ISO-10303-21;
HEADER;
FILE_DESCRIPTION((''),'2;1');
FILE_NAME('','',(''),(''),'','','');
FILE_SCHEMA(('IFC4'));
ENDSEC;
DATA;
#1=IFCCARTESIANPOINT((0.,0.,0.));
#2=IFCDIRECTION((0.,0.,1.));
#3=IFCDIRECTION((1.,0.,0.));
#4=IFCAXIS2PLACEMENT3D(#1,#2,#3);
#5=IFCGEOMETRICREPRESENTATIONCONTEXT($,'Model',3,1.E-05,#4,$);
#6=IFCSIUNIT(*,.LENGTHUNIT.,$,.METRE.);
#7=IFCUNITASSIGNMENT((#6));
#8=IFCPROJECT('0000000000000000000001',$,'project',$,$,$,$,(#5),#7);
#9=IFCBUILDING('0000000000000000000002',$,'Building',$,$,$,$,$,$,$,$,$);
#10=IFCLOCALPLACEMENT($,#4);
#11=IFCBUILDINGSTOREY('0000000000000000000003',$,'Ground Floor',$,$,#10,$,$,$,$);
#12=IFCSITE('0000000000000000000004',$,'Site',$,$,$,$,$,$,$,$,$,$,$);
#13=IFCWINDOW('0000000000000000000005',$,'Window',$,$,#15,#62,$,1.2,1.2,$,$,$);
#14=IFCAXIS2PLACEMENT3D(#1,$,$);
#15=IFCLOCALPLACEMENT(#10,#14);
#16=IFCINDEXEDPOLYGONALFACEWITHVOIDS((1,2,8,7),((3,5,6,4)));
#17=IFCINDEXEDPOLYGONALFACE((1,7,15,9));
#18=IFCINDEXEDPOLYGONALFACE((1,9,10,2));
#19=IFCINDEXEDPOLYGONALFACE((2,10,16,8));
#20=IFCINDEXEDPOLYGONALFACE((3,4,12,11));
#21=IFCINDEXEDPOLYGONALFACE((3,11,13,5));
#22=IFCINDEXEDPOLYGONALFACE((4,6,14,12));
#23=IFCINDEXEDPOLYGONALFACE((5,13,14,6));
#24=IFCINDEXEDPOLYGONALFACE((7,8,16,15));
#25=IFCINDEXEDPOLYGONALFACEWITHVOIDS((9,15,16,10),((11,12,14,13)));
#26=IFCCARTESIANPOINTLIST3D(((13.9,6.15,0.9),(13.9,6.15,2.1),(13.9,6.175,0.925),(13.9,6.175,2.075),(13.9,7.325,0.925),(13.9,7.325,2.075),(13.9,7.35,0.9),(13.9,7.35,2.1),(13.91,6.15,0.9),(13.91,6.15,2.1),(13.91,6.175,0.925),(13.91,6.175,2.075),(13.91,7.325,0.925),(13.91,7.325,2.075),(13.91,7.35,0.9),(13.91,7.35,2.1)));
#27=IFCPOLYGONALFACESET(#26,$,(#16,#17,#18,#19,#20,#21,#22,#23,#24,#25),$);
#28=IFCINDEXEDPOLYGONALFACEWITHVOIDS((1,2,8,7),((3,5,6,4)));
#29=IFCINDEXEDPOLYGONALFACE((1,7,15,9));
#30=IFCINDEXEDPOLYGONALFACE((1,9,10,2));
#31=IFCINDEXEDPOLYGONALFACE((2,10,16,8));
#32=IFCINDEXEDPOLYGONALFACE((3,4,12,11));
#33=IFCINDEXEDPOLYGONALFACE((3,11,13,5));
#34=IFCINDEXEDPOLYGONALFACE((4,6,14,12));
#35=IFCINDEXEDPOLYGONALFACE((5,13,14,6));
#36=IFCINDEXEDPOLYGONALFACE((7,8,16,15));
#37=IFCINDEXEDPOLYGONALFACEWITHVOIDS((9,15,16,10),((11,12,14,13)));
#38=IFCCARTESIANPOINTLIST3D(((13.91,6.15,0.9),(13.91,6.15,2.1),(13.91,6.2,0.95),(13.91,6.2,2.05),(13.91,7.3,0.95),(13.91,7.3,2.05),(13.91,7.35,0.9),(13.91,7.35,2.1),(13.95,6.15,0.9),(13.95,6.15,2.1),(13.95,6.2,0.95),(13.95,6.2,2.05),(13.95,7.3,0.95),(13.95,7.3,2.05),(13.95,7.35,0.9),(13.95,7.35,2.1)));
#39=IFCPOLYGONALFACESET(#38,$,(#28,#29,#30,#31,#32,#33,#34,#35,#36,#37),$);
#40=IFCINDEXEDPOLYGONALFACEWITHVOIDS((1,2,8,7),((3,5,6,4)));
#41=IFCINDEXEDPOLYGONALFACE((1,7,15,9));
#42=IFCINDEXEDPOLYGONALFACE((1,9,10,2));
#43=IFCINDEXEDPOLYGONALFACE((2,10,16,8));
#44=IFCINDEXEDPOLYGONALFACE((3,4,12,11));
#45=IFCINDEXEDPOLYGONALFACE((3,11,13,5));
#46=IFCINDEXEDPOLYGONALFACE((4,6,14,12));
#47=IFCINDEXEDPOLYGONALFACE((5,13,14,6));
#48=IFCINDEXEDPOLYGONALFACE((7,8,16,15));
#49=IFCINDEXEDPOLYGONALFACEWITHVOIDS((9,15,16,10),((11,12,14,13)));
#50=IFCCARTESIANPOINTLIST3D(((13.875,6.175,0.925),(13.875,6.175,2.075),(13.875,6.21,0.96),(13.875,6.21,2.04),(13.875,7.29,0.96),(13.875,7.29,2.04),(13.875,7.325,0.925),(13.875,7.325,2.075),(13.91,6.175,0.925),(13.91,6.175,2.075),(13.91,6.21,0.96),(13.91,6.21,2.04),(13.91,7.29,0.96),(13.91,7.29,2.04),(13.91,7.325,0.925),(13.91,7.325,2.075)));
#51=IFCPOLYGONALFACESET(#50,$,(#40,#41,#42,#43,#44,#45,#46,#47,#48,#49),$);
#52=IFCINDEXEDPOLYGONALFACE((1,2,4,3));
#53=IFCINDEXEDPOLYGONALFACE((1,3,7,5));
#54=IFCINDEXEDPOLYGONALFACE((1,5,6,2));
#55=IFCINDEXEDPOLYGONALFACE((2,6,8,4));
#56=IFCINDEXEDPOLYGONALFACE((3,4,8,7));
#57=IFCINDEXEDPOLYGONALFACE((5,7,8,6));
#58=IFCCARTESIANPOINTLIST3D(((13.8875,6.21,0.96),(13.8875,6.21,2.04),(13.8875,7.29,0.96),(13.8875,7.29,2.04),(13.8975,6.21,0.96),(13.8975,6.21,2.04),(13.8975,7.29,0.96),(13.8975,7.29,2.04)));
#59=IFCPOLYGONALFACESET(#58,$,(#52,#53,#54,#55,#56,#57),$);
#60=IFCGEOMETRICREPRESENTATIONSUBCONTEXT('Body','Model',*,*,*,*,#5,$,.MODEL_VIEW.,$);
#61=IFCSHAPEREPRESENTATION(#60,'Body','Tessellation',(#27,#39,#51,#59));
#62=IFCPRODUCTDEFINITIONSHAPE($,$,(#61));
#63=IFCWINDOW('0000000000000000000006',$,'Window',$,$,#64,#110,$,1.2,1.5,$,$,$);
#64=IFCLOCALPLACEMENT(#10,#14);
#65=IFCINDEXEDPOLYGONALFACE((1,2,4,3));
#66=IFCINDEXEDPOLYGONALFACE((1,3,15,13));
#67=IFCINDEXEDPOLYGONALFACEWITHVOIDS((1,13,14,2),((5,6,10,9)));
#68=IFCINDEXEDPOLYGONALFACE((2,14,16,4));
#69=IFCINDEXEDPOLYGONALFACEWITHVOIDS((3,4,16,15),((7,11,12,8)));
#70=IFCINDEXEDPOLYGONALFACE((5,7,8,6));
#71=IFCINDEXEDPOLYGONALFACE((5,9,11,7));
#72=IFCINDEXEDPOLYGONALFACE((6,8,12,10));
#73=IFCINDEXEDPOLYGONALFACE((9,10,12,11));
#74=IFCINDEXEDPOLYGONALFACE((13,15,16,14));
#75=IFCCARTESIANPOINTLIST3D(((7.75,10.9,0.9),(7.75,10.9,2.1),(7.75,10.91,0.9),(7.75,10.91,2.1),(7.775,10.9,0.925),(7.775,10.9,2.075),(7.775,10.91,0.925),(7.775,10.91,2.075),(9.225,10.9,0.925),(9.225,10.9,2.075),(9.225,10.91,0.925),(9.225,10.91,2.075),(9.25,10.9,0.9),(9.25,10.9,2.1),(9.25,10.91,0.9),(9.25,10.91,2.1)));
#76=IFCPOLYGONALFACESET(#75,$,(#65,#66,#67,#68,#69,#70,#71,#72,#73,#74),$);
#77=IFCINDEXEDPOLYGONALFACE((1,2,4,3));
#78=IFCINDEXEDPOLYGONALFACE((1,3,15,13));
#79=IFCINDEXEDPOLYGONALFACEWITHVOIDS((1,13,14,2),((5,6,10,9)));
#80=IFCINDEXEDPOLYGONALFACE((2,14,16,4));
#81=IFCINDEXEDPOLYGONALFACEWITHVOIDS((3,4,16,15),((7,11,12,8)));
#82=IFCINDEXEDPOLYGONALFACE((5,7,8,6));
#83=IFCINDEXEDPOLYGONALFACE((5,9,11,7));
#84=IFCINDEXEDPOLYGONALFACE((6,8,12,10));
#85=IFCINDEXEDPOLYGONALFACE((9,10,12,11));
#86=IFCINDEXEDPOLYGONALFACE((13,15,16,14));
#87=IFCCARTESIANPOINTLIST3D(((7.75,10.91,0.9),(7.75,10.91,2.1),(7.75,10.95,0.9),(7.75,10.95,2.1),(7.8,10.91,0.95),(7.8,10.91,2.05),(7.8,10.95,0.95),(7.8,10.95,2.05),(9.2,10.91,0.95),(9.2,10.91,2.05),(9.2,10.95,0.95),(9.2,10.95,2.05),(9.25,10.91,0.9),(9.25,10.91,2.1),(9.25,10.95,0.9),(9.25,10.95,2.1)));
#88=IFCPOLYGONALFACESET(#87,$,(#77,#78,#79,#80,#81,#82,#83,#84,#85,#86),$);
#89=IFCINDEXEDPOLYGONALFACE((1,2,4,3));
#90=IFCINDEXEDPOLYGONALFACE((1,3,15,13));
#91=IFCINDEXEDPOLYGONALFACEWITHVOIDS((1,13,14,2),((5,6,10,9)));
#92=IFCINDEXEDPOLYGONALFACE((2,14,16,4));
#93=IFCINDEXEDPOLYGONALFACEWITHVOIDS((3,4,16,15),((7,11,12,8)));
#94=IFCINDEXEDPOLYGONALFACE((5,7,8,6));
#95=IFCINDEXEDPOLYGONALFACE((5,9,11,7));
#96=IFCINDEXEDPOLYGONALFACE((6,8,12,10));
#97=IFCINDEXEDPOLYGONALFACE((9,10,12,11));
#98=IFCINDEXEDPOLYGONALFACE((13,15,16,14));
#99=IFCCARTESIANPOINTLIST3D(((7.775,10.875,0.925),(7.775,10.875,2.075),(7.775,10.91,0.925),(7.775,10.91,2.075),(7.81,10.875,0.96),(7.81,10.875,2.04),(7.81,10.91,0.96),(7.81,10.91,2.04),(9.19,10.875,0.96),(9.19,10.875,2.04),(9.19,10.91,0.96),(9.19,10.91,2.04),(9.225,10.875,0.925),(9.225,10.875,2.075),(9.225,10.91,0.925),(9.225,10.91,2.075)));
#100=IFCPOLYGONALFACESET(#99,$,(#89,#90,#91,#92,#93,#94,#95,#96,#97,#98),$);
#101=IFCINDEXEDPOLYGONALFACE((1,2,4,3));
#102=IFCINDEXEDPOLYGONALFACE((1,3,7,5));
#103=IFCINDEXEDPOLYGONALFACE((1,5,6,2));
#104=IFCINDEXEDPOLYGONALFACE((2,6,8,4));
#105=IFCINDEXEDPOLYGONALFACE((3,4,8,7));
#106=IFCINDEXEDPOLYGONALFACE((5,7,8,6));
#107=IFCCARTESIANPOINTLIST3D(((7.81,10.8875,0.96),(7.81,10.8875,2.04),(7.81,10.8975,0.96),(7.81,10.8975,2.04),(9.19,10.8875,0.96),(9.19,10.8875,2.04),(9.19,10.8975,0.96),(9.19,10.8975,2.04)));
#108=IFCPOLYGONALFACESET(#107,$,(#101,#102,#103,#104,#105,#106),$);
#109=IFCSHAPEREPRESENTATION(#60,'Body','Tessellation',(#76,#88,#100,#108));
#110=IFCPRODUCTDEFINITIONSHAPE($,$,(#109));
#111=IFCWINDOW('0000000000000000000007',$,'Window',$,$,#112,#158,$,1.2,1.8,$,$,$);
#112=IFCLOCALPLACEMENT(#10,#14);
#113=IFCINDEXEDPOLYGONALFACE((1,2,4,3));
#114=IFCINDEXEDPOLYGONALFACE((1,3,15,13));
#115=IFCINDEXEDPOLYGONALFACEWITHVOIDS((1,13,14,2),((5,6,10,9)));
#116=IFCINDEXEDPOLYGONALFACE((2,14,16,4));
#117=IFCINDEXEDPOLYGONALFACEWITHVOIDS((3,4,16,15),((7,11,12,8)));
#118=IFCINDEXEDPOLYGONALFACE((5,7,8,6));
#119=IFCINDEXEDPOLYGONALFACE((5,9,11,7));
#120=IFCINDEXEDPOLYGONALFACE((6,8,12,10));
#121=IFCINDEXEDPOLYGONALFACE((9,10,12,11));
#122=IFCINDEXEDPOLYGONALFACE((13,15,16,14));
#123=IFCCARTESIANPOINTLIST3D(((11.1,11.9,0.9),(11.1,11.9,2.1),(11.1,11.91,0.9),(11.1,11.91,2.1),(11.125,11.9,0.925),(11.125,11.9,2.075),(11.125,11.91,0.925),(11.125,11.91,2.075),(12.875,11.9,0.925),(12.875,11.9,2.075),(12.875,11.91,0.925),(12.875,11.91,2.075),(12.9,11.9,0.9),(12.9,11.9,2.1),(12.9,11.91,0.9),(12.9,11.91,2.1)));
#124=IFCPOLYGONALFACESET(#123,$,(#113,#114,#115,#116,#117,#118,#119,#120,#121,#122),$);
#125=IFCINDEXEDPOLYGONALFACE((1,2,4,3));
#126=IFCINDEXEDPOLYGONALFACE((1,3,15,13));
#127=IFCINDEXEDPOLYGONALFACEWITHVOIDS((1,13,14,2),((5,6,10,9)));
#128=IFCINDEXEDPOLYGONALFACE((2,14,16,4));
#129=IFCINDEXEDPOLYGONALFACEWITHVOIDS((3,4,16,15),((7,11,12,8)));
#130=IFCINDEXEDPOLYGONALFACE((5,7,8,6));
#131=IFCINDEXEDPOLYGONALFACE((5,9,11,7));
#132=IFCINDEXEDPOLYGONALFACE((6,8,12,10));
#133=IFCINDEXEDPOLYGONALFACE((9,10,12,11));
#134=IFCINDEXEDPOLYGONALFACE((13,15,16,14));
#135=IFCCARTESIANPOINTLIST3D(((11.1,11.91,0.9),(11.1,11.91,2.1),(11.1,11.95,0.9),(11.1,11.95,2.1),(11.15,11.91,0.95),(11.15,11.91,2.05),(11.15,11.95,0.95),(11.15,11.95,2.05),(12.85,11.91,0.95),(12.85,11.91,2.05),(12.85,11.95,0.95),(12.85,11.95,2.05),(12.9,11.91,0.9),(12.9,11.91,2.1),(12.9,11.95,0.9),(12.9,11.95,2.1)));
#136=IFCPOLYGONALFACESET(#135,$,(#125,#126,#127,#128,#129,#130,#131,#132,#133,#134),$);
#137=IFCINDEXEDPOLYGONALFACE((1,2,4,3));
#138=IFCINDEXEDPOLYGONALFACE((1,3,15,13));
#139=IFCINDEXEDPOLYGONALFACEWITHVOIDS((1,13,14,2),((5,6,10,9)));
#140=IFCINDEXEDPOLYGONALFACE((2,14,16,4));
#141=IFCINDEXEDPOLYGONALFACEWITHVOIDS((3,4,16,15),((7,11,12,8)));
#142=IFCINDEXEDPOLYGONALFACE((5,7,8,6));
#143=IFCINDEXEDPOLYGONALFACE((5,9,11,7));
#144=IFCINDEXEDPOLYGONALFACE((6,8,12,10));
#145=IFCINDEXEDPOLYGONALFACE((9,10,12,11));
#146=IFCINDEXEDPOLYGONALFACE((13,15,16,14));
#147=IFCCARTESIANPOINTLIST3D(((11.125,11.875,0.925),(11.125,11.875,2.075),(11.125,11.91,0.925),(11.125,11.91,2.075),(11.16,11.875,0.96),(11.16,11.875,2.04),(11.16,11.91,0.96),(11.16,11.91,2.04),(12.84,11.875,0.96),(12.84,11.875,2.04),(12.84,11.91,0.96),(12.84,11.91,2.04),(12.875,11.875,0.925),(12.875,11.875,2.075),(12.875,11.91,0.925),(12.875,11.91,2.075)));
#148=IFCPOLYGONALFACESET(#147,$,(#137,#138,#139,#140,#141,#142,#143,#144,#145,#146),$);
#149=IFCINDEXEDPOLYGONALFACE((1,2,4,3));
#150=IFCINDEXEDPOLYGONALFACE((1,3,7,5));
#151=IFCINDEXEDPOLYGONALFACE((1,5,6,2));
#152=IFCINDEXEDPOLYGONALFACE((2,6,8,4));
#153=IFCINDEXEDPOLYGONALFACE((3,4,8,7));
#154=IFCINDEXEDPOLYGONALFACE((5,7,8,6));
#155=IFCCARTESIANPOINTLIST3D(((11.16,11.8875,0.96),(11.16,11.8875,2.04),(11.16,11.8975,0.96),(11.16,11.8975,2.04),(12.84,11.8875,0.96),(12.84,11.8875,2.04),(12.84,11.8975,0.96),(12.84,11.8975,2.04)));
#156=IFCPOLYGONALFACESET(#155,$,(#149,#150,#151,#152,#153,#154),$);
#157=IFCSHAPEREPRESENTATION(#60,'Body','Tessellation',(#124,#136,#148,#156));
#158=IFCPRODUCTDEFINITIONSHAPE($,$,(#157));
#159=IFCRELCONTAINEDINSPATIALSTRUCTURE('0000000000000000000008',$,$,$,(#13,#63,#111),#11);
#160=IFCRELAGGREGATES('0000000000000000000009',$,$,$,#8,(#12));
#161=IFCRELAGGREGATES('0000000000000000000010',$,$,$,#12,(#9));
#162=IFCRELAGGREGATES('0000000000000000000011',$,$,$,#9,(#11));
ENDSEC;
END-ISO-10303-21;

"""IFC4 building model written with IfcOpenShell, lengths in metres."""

from ifc_helpers import new_model, si_unit, frame, origin_with_axes, place, context, subcontext, project, spatial, line, indexed_curve, outline, extrude, element, save


model = new_model("IFC4")

# Units and contexts
model_context = context("Model", 3, precision=1e-05, world=origin_with_axes())
body_context = subcontext(model_context, "Body", "Model", "MODEL_VIEW")
ifc_project = project(units=[si_unit("LENGTHUNIT", "METRE")], contexts=[model_context])

# Site, building, storey
site = spatial("IfcSite", under=ifc_project, Name="Site")
building = spatial("IfcBuilding", under=site, Name="Building")
storey_placement = place(None, origin_with_axes())
storey = spatial("IfcBuildingStorey", under=building, at=storey_placement, Name="Ground Floor")

# Windows
window_1_placement = place(storey_placement, frame((14.0, 6.15, 0.9), z_axis=(0.0, 0.0, 1.0), x_axis=(0.0, 1.0, 0.0)))
element("IfcWindow", 1, at=window_1_placement, inside=storey, Name="Window", OverallHeight=1.2, OverallWidth=1.2, context=body_context, shape_type="SweptSolid", body=[
    extrude(outline(indexed_curve([(0.0, 0.0), (1.2, 0.0), (1.2, 1.2), (0.0, 1.2)], segments=[line(1, 2, 3, 4, 1)]), holes=[indexed_curve([(0.025, 0.025), (1.175, 0.025), (1.175, 1.175), (0.025, 1.175)], segments=[line(1, 2, 3, 4, 1)])]), frame((0.0, 0.09, 0.0), z_axis=(0.0, -1.0, 0.0), x_axis=(1.0, 0.0, 0.0)), (0.0, 0.0, -1.0), 0.01),
    extrude(outline(indexed_curve([(0.0, 0.0), (1.2, 0.0), (1.2, 1.2), (0.0, 1.2)], segments=[line(1, 2, 3, 4, 1)]), holes=[indexed_curve([(0.05, 0.05), (1.15, 0.05), (1.15, 1.15), (0.05, 1.15)], segments=[line(1, 2, 3, 4, 1)])]), frame((0.0, 0.05, 0.0), z_axis=(0.0, -1.0, 0.0), x_axis=(1.0, 0.0, 0.0)), (0.0, 0.0, -1.0), 0.04),
    extrude(outline(indexed_curve([(0.0, 0.0), (1.15, 0.0), (1.15, 1.15), (0.0, 1.15)], segments=[line(1, 2, 3, 4, 1)]), holes=[indexed_curve([(0.035, 0.035), (1.115, 0.035), (1.115, 1.115), (0.035, 1.115)], segments=[line(1, 2, 3, 4, 1)])]), frame((0.025, 0.09, 0.025), z_axis=(0.0, -1.0, 0.0), x_axis=(1.0, 0.0, 0.0)), (0.0, 0.0, -1.0), 0.035),
    extrude(outline(indexed_curve([(0.035, 0.035), (1.115, 0.035), (1.115, 1.115), (0.035, 1.115)], segments=[line(1, 2, 3, 4, 1)])), frame((0.025, 0.1025, 0.025), z_axis=(0.0, -1.0, 0.0), x_axis=(1.0, 0.0, 0.0)), (0.0, 0.0, -1.0), 0.01),
])
window_2_placement = place(storey_placement, frame((9.25, 11.0, 0.9), z_axis=(0.0, 0.0, 1.0), x_axis=(-1.0, 0.0, 0.0)))
element("IfcWindow", 2, at=window_2_placement, inside=storey, Name="Window", OverallHeight=1.2, OverallWidth=1.5, context=body_context, shape_type="SweptSolid", body=[
    extrude(outline(indexed_curve([(0.0, 0.0), (1.5, 0.0), (1.5, 1.2), (0.0, 1.2)], segments=[line(1, 2, 3, 4, 1)]), holes=[indexed_curve([(0.025, 0.025), (1.475, 0.025), (1.475, 1.175), (0.025, 1.175)], segments=[line(1, 2, 3, 4, 1)])]), frame((0.0, 0.09, 0.0), z_axis=(0.0, -1.0, 0.0), x_axis=(1.0, 0.0, 0.0)), (0.0, 0.0, -1.0), 0.01),
    extrude(outline(indexed_curve([(0.0, 0.0), (1.5, 0.0), (1.5, 1.2), (0.0, 1.2)], segments=[line(1, 2, 3, 4, 1)]), holes=[indexed_curve([(0.05, 0.05), (1.45, 0.05), (1.45, 1.15), (0.05, 1.15)], segments=[line(1, 2, 3, 4, 1)])]), frame((0.0, 0.05, 0.0), z_axis=(0.0, -1.0, 0.0), x_axis=(1.0, 0.0, 0.0)), (0.0, 0.0, -1.0), 0.04),
    extrude(outline(indexed_curve([(0.0, 0.0), (1.45, 0.0), (1.45, 1.15), (0.0, 1.15)], segments=[line(1, 2, 3, 4, 1)]), holes=[indexed_curve([(0.035, 0.035), (1.415, 0.035), (1.415, 1.115), (0.035, 1.115)], segments=[line(1, 2, 3, 4, 1)])]), frame((0.025, 0.09, 0.025), z_axis=(0.0, -1.0, 0.0), x_axis=(1.0, 0.0, 0.0)), (0.0, 0.0, -1.0), 0.035),
    extrude(outline(indexed_curve([(0.035, 0.035), (1.415, 0.035), (1.415, 1.115), (0.035, 1.115)], segments=[line(1, 2, 3, 4, 1)])), frame((0.025, 0.1025, 0.025), z_axis=(0.0, -1.0, 0.0), x_axis=(1.0, 0.0, 0.0)), (0.0, 0.0, -1.0), 0.01),
])
window_3_placement = place(storey_placement, frame((12.9, 12.0, 0.9), z_axis=(0.0, 0.0, 1.0), x_axis=(-1.0, 0.0, 0.0)))
element("IfcWindow", 3, at=window_3_placement, inside=storey, Name="Window", OverallHeight=1.2, OverallWidth=1.8, context=body_context, shape_type="SweptSolid", body=[
    extrude(outline(indexed_curve([(0.0, 0.0), (1.8, 0.0), (1.8, 1.2), (0.0, 1.2)], segments=[line(1, 2, 3, 4, 1)]), holes=[indexed_curve([(0.025, 0.025), (1.775, 0.025), (1.775, 1.175), (0.025, 1.175)], segments=[line(1, 2, 3, 4, 1)])]), frame((0.0, 0.09, 0.0), z_axis=(0.0, -1.0, 0.0), x_axis=(1.0, 0.0, 0.0)), (0.0, 0.0, -1.0), 0.01),
    extrude(outline(indexed_curve([(0.0, 0.0), (1.8, 0.0), (1.8, 1.2), (0.0, 1.2)], segments=[line(1, 2, 3, 4, 1)]), holes=[indexed_curve([(0.05, 0.05), (1.75, 0.05), (1.75, 1.15), (0.05, 1.15)], segments=[line(1, 2, 3, 4, 1)])]), frame((0.0, 0.05, 0.0), z_axis=(0.0, -1.0, 0.0), x_axis=(1.0, 0.0, 0.0)), (0.0, 0.0, -1.0), 0.04),
    extrude(outline(indexed_curve([(0.0, 0.0), (1.75, 0.0), (1.75, 1.15), (0.0, 1.15)], segments=[line(1, 2, 3, 4, 1)]), holes=[indexed_curve([(0.035, 0.035), (1.715, 0.035), (1.715, 1.115), (0.035, 1.115)], segments=[line(1, 2, 3, 4, 1)])]), frame((0.025, 0.09, 0.025), z_axis=(0.0, -1.0, 0.0), x_axis=(1.0, 0.0, 0.0)), (0.0, 0.0, -1.0), 0.035),
    extrude(outline(indexed_curve([(0.035, 0.035), (1.715, 0.035), (1.715, 1.115), (0.035, 1.115)], segments=[line(1, 2, 3, 4, 1)])), frame((0.025, 0.1025, 0.025), z_axis=(0.0, -1.0, 0.0), x_axis=(1.0, 0.0, 0.0)), (0.0, 0.0, -1.0), 0.01),
])

save(model, "model.ifc")
